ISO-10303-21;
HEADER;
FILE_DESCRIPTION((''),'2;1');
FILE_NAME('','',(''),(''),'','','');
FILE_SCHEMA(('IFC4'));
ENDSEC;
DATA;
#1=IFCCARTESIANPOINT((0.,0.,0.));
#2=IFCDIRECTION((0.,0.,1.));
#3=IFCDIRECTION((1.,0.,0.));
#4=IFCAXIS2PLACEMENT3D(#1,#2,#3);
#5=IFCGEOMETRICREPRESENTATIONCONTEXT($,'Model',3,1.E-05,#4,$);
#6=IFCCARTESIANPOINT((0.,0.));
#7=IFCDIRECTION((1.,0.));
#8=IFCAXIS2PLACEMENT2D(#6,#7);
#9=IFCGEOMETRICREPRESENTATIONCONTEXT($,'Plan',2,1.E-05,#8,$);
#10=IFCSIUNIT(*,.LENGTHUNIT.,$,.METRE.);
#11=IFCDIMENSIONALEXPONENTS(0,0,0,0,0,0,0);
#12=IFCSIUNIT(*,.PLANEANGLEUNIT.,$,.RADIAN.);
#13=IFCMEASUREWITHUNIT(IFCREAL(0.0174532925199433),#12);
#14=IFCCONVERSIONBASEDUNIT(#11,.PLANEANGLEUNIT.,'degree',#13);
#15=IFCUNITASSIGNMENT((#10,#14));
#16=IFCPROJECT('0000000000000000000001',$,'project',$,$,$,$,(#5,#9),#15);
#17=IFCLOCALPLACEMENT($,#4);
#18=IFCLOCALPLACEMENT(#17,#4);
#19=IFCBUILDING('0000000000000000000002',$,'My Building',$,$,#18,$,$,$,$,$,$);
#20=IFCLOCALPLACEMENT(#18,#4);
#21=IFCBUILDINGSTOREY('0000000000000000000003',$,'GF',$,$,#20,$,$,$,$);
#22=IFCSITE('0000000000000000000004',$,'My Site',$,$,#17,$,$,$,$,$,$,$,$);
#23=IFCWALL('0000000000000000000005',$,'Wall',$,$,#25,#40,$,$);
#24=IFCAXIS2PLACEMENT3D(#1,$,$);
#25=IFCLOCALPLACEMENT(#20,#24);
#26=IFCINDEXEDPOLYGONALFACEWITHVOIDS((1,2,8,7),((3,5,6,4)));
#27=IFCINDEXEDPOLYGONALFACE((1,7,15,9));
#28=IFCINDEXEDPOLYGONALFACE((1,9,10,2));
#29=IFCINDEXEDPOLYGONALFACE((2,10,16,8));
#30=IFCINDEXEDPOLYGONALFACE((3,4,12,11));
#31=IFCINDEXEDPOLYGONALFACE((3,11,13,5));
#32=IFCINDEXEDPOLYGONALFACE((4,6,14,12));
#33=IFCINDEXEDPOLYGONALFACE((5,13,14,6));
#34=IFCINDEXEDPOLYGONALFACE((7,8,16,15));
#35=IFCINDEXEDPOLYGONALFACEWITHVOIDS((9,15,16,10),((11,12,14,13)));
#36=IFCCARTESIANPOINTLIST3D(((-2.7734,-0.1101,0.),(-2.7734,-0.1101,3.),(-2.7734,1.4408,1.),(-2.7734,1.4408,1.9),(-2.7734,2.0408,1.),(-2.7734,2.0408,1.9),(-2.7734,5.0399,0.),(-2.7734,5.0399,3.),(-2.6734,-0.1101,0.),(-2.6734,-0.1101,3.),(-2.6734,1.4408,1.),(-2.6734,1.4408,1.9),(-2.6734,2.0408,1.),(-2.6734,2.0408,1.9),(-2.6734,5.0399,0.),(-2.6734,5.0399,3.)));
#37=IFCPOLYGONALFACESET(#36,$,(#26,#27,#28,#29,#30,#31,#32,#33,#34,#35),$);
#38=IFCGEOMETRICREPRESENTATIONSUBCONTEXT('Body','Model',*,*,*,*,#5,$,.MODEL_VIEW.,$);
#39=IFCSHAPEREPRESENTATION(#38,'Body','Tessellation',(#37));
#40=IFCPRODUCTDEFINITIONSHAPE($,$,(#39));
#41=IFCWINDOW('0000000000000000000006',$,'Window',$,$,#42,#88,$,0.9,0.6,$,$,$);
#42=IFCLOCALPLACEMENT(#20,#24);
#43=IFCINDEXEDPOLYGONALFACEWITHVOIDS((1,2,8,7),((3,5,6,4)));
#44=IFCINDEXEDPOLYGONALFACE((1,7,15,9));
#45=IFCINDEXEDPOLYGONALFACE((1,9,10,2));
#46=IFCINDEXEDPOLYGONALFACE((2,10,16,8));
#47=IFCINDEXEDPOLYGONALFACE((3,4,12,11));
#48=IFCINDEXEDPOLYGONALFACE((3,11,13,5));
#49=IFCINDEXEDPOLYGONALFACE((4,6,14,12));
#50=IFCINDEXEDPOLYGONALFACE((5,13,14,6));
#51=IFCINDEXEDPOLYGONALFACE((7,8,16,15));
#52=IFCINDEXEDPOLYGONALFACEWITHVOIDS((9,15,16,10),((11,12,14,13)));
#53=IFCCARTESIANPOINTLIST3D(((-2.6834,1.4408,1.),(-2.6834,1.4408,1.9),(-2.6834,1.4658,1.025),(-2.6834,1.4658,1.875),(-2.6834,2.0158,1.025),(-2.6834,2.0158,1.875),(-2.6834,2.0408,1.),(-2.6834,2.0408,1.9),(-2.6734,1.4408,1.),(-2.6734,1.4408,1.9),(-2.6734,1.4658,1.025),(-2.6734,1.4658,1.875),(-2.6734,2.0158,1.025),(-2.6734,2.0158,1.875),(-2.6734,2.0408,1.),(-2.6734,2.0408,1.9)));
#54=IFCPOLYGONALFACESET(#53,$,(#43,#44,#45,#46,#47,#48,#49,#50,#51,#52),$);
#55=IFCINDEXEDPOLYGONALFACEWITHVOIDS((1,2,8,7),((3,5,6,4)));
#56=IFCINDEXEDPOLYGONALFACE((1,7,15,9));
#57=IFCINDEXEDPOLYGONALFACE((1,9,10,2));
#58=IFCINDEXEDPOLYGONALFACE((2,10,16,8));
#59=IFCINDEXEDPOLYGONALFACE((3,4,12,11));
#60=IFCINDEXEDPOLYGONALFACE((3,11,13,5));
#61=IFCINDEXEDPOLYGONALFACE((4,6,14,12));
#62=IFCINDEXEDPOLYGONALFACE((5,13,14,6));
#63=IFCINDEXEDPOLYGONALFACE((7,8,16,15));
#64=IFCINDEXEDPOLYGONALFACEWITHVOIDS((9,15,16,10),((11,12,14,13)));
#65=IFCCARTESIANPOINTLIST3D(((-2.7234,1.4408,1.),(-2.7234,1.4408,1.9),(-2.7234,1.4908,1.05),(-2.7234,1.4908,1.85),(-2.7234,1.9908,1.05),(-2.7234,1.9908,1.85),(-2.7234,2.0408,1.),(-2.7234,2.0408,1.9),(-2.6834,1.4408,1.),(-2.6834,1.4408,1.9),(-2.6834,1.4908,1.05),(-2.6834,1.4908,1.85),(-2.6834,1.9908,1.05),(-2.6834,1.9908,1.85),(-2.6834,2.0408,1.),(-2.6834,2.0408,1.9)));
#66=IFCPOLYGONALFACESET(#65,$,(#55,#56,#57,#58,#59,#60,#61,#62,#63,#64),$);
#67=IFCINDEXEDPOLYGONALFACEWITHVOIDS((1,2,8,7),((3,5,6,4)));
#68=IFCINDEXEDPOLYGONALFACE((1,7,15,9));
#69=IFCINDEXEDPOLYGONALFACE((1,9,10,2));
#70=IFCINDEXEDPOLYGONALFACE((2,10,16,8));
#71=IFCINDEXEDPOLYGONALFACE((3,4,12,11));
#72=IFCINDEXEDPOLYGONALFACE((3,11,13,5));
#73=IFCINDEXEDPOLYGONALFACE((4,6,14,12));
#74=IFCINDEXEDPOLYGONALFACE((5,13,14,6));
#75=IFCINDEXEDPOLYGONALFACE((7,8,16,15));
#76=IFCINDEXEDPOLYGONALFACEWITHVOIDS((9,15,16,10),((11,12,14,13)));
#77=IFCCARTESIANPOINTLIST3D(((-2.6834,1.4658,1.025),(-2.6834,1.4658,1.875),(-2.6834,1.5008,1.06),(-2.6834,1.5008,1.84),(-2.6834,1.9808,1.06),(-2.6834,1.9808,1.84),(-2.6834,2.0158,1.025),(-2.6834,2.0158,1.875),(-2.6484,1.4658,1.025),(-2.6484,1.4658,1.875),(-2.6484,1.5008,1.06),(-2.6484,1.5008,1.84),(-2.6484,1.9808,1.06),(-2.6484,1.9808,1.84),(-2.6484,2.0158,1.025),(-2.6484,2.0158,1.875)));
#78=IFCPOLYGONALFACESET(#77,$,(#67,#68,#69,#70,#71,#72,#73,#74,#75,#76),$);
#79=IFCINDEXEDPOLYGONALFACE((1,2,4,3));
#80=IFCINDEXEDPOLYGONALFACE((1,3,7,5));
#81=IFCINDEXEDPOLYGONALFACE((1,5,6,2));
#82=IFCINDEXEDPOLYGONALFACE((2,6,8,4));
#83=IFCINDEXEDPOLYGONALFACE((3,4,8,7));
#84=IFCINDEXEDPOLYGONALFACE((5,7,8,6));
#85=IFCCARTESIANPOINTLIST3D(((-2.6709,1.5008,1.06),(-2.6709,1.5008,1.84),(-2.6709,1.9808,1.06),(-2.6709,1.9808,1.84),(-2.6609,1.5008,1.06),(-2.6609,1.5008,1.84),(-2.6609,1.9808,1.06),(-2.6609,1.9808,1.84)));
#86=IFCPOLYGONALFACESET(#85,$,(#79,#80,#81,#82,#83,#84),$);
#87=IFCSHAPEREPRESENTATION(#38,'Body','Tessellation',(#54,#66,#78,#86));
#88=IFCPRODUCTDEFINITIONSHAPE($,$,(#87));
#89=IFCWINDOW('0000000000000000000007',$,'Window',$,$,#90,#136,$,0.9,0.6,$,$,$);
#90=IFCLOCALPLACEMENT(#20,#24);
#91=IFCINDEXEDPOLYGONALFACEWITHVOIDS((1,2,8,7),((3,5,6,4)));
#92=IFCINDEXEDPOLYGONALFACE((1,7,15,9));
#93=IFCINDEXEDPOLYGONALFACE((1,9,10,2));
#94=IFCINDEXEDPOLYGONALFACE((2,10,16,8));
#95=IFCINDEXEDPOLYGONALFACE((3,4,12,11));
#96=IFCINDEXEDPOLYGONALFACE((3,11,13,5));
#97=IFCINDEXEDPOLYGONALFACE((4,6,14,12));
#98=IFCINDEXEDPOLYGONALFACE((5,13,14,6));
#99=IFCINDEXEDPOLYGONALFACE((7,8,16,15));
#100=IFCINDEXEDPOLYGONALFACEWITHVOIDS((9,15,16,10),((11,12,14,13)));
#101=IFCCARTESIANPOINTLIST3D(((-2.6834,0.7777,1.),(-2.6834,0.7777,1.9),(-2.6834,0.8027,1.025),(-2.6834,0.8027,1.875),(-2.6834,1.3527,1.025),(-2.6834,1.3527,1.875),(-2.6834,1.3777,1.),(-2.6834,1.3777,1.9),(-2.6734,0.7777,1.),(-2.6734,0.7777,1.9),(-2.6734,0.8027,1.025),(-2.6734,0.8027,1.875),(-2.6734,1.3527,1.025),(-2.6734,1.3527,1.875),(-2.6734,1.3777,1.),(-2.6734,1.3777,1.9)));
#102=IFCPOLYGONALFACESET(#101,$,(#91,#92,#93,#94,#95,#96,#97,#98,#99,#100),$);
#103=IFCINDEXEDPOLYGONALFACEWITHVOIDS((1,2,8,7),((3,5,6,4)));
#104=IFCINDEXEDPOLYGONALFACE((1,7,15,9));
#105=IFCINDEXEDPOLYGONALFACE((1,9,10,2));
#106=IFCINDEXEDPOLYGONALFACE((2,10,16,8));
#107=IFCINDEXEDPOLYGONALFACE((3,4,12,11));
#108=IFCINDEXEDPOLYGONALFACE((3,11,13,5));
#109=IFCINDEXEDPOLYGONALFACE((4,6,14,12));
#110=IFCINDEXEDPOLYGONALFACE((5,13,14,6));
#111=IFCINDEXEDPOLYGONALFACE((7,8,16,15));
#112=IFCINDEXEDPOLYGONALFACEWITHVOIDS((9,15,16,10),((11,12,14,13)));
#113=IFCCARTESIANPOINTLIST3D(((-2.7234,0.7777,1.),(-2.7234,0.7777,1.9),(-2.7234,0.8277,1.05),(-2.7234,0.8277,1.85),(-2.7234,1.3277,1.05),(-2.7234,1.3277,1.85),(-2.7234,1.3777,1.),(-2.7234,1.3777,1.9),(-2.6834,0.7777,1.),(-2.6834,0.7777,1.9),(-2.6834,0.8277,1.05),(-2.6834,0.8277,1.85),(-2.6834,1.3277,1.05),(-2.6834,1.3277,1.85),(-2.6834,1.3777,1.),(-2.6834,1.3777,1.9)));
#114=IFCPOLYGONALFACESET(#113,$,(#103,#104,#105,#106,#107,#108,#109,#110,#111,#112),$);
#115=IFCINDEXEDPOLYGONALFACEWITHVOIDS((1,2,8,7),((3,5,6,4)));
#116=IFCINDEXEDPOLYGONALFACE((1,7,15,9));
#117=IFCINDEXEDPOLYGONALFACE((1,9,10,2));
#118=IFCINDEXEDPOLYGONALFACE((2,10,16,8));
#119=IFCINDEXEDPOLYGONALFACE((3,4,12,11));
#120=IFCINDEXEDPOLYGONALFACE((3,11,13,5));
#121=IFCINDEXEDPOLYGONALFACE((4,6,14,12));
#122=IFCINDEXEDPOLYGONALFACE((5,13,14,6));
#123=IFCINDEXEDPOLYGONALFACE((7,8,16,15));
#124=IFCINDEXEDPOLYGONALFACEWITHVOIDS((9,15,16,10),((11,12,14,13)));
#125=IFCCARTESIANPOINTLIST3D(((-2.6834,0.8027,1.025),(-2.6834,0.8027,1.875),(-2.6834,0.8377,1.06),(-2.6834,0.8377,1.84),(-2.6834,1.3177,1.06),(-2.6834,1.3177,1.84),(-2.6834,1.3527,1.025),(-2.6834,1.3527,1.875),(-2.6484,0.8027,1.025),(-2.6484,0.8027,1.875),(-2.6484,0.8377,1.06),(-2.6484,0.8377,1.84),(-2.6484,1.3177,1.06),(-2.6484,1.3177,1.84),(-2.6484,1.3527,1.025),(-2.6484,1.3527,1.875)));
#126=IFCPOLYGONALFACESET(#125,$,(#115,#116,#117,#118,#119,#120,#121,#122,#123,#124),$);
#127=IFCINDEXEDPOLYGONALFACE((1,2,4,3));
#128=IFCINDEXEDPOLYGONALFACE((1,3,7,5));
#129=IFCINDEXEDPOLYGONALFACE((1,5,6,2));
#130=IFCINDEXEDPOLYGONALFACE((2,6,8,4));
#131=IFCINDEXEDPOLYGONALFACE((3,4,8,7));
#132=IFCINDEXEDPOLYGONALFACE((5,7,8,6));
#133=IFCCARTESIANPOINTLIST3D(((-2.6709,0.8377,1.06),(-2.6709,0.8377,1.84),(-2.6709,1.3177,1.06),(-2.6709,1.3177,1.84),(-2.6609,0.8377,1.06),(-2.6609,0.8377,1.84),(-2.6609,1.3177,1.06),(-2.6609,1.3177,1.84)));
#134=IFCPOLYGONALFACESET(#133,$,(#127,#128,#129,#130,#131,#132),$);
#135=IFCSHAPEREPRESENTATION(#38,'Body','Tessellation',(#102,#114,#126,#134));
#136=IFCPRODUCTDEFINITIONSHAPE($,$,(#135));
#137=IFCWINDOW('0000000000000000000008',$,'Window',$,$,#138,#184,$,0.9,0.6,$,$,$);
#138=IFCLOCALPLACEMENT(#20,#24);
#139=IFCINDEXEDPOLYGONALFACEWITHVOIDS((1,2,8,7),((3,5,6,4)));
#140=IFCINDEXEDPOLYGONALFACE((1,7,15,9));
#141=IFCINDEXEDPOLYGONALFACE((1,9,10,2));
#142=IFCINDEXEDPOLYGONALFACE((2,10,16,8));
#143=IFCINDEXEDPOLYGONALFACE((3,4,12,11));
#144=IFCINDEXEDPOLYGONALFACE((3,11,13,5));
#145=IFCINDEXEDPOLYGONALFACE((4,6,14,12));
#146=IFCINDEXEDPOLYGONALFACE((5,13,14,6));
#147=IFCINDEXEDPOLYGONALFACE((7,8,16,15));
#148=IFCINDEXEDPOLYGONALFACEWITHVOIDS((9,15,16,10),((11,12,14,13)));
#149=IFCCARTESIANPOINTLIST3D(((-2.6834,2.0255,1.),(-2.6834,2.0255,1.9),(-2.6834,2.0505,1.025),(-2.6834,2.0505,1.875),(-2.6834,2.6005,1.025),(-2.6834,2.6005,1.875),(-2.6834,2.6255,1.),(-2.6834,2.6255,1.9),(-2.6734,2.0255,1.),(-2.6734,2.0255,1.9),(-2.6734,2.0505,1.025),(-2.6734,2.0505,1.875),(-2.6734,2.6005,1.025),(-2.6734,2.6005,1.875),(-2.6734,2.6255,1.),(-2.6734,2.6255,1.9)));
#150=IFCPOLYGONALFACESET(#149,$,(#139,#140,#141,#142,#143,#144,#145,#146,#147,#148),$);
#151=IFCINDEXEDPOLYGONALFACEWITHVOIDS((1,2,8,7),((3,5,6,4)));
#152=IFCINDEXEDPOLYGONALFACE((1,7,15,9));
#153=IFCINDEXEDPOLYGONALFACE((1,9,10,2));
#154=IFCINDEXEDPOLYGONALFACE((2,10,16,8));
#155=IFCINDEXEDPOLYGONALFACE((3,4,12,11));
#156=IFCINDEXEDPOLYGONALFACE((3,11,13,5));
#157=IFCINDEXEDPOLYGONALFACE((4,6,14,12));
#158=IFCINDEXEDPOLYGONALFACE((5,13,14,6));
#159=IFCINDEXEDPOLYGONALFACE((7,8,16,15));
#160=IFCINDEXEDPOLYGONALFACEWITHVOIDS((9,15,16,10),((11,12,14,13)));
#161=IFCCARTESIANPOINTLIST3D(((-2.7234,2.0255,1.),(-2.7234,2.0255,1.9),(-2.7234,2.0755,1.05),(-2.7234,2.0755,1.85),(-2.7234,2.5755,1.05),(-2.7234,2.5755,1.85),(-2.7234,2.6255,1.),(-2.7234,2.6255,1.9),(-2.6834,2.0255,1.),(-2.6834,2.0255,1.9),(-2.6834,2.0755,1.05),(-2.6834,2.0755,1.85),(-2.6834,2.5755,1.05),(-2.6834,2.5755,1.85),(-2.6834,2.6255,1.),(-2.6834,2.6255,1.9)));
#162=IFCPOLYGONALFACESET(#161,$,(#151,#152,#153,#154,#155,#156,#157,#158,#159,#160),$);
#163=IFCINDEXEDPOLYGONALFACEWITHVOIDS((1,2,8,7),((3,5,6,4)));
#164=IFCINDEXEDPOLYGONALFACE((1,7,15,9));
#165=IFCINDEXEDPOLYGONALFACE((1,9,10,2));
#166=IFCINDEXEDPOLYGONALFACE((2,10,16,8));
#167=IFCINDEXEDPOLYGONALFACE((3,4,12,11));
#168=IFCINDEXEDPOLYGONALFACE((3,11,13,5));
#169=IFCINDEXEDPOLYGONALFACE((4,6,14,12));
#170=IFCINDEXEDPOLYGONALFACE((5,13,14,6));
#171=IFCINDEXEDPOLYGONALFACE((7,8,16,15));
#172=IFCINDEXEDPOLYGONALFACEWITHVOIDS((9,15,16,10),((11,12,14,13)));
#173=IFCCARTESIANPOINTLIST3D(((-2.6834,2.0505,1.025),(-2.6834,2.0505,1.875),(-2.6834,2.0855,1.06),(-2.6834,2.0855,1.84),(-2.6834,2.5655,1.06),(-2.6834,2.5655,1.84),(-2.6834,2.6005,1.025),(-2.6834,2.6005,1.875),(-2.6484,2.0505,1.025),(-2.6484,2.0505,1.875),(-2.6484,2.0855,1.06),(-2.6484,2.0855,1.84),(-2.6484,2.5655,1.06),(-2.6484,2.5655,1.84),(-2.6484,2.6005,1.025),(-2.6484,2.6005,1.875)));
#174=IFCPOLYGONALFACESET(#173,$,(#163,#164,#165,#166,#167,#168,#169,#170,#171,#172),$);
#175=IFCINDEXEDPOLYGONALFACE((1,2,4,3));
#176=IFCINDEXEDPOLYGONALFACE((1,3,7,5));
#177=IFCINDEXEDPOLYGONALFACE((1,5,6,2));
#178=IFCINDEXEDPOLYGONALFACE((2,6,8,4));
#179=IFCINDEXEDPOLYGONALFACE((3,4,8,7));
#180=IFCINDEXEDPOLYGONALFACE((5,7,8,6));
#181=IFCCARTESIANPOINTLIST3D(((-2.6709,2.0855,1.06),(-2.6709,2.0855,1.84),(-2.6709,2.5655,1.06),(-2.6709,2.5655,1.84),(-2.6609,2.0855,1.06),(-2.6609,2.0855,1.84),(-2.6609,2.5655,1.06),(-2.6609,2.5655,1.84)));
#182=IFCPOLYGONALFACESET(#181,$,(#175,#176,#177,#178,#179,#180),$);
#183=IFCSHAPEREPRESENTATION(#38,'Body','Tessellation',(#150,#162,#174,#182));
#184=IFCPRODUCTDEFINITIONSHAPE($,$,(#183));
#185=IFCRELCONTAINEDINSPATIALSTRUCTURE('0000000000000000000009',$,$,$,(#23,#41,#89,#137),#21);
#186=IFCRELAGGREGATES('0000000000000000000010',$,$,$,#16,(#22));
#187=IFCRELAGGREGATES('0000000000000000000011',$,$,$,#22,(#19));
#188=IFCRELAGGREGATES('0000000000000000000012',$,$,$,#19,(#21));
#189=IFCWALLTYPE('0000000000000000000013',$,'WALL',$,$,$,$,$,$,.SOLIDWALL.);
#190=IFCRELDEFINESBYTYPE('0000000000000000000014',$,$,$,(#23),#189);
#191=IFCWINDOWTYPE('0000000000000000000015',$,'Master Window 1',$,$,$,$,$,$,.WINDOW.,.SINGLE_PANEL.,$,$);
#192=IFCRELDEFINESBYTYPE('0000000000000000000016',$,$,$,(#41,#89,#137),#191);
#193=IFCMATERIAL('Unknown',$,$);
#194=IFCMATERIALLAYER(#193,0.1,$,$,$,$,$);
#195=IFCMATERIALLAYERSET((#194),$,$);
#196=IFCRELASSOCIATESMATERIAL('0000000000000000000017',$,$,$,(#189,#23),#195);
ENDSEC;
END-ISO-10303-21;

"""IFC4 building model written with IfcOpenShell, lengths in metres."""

from ifc_helpers import new_model, entity, si_unit, converted_unit, frame, origin_with_axes, origin_2d_with_axis, place, context, subcontext, project, spatial, line, indexed_curve, outline, extrude, shape, source, transform, mapped, material, layer, layer_set, layer_usage, type_object, type_shapes, element, fill, save


model = new_model("IFC4")

# Units and contexts
model_context = context("Model", 3, precision=1e-05, world=origin_with_axes())
plan_context = context("Plan", 2, precision=1e-05, world=origin_2d_with_axis())
body_context_1 = subcontext(model_context, "Body", "Model", "MODEL_VIEW")
body_context_2 = subcontext(plan_context, "Body", "Plan", "PLAN_VIEW")
ifc_project = project(units=[si_unit("LENGTHUNIT", "METRE"), converted_unit("PLANEANGLEUNIT", "degree", entity("IfcReal", 0.0174532925199433), si_unit("PLANEANGLEUNIT", "RADIAN"), dimensions=[0, 0, 0, 0, 0, 0, 0])], contexts=[model_context, plan_context])

# Site, building, storey
site_placement = place(None, origin_with_axes())
site = spatial("IfcSite", under=ifc_project, at=site_placement, Name="My Site")
building_placement = place(site_placement, origin_with_axes())
building = spatial("IfcBuilding", under=site, at=building_placement, Name="My Building")
storey_placement = place(building_placement, origin_with_axes())
storey = spatial("IfcBuildingStorey", under=building, at=storey_placement, Name="GF")

# Shared definitions
ifc_material = material(Name="Unknown")

# Shared definitions
ifc_layer_1 = layer(ifc_material, 0.1)
ifc_layer_set_1 = layer_set([ifc_layer_1])
wall_type_1 = type_object("IfcWallType", Name="WALL", PredefinedType="SOLIDWALL", material=ifc_layer_set_1)

# Shared definitions
shared_shape_1 = source(origin_with_axes(), body_context_1, "Body", "SweptSolid", [
    extrude(outline(indexed_curve([(0.0, 0.0), (0.6, 0.0), (0.6, 0.9), (0.0, 0.9)], segments=[line(1, 2, 3, 4, 1)])), frame((0.0, -0.6, 0.0), z_axis=(0.0, -1.0, 0.0), x_axis=(1.0, 0.0, 0.0)), (0.0, 0.0, -1.0), 1.2),
])
window_type_1 = type_object("IfcWindowType", Name="Master Window 1", PartitioningType="SINGLE_PANEL", PredefinedType="WINDOW")
shared_shape_2 = source(origin_with_axes(), body_context_1, "Body", "SweptSolid", [
    extrude(outline(indexed_curve([(0.0, 0.0), (0.6, 0.0), (0.6, 0.9), (0.0, 0.9)], segments=[line(1, 2, 3, 4, 1)]), holes=[indexed_curve([(0.025, 0.025), (0.575, 0.025), (0.575, 0.875), (0.025, 0.875)], segments=[line(1, 2, 3, 4, 1)])]), frame((0.0, 0.09, 0.0), z_axis=(0.0, -1.0, 0.0), x_axis=(1.0, 0.0, 0.0)), (0.0, 0.0, -1.0), 0.01),
    extrude(outline(indexed_curve([(0.0, 0.0), (0.6, 0.0), (0.6, 0.9), (0.0, 0.9)], segments=[line(1, 2, 3, 4, 1)]), holes=[indexed_curve([(0.05, 0.05), (0.55, 0.05), (0.55, 0.85), (0.05, 0.85)], segments=[line(1, 2, 3, 4, 1)])]), frame((0.0, 0.05, 0.0), z_axis=(0.0, -1.0, 0.0), x_axis=(1.0, 0.0, 0.0)), (0.0, 0.0, -1.0), 0.04),
    extrude(outline(indexed_curve([(0.0, 0.0), (0.55, 0.0), (0.55, 0.85), (0.0, 0.85)], segments=[line(1, 2, 3, 4, 1)]), holes=[indexed_curve([(0.035, 0.035), (0.515, 0.035), (0.515, 0.815), (0.035, 0.815)], segments=[line(1, 2, 3, 4, 1)])]), frame((0.025, 0.09, 0.025), z_axis=(0.0, -1.0, 0.0), x_axis=(1.0, 0.0, 0.0)), (0.0, 0.0, -1.0), 0.035),
    extrude(outline(indexed_curve([(0.035, 0.035), (0.515, 0.035), (0.515, 0.815), (0.035, 0.815)], segments=[line(1, 2, 3, 4, 1)])), frame((0.025, 0.1025, 0.025), z_axis=(0.0, -1.0, 0.0), x_axis=(1.0, 0.0, 0.0)), (0.0, 0.0, -1.0), 0.01),
])
shared_shape_3 = source(origin_with_axes(), body_context_2, "Body", "Curve2D", [
    entity("IfcIndexedPolyCurve", entity("IfcCartesianPointList2D", [[0.05, 0.05], [0.55, 0.05]])),
    entity("IfcIndexedPolyCurve", entity("IfcCartesianPointList2D", [[0.0, 0.1], [0.025, 0.1], [0.025, 0.09], [0.05, 0.09], [0.05, 0.05], [0.0, 0.05]]), [entity("IfcLineIndex", [1, 2, 3, 4, 5, 6, 1])]),
    entity("IfcIndexedPolyCurve", entity("IfcCartesianPointList2D", [[0.6, 0.1], [0.575, 0.1], [0.575, 0.09], [0.55, 0.09], [0.55, 0.05], [0.6, 0.05]]), [entity("IfcLineIndex", [1, 2, 3, 4, 5, 6, 1])]),
    entity("IfcIndexedPolyCurve", entity("IfcCartesianPointList2D", [[0.025, 0.09], [0.06, 0.09], [0.06, 0.125], [0.025, 0.125]]), [entity("IfcLineIndex", [1, 2, 3, 4, 1])]),
    entity("IfcIndexedPolyCurve", entity("IfcCartesianPointList2D", [[0.575, 0.09], [0.54, 0.09], [0.54, 0.125], [0.575, 0.125]]), [entity("IfcLineIndex", [1, 2, 3, 4, 1])]),
    entity("IfcIndexedPolyCurve", entity("IfcCartesianPointList2D", [[0.06, 0.09], [0.54, 0.09]])),
    entity("IfcIndexedPolyCurve", entity("IfcCartesianPointList2D", [[0.06, 0.125], [0.54, 0.125]])),
    entity("IfcIndexedPolyCurve", entity("IfcCartesianPointList2D", [[0.06, 0.1075], [0.54, 0.1075]])),
])
type_shapes(window_type_1, [shared_shape_2, shared_shape_3])

# Wall, opening, window
ifc_layer_usage_1 = layer_usage(ifc_layer_set_1, "AXIS2", "POSITIVE", 0.0)
wall_1_placement = place(storey_placement, frame((-2.7734, 5.0399, 0.0), z_axis=(0.0, 0.0, 1.0), x_axis=(0.0, -1.0, 0.0)))
wall_1 = element("IfcWall", 1, at=wall_1_placement, inside=storey, type_object=wall_type_1, material=ifc_layer_usage_1, Name="Wall", context=body_context_1, shape_type="SweptSolid", body=[
    extrude(outline(indexed_curve([(0.0, 0.0), (0.0, 0.1), (5.15, 0.1), (5.15, 0.0)], segments=[line(1, 2, 3, 4, 1)])), origin_with_axes(), (0.0, 0.0, 1.0), 3.0),
])
opening_1_placement = place(wall_1_placement, frame((2.9991, 0.0, 1.0), z_axis=(0.0, 0.0, 1.0), x_axis=(1.0, 0.0, 0.0)))
opening_1 = element("IfcOpeningElement", 2, at=opening_1_placement, cuts=wall_1, PredefinedType="OPENING", context=body_context_1, shape_type="MappedRepresentation", body=[
    mapped(shared_shape_1, transform((0.0, 0.0, 0.0), x_axis=(1.0, 0.0, 0.0), y_axis=(0.0, 1.0, 0.0), z_axis=(0.0, 0.0, 1.0), scale=1.0)),
])
window_1_placement = place(opening_1_placement, frame((0.0, 0.0, 0.0), z_axis=(0.0, 0.0, 1.0), x_axis=(1.0, 0.0, 0.0)))
window_1 = element("IfcWindow", 3, at=window_1_placement, inside=storey, type_object=window_type_1, Name="Window", OverallHeight=0.9, OverallWidth=0.6, shapes=[
    shape(body_context_1, "Body", "MappedRepresentation", [mapped(shared_shape_2, transform((0.0, 0.0, 0.0), x_axis=(1.0, 0.0, 0.0), y_axis=(0.0, 1.0, 0.0), z_axis=(0.0, 0.0, 1.0), scale=1.0))]),
    shape(body_context_2, "Body", "MappedRepresentation", [mapped(shared_shape_3, transform((0.0, 0.0, 0.0), x_axis=(1.0, 0.0, 0.0), y_axis=(0.0, 1.0, 0.0), z_axis=(0.0, 0.0, 1.0), scale=1.0))]),
])
fill(opening_1, window_1)

# Windows
placement_1 = place(storey_placement, frame((-2.7734, 5.0399, 0.0), z_axis=(0.0, 0.0, 1.0), x_axis=(0.0, -1.0, 0.0)))
placement_2 = place(placement_1, frame((3.6622, 0.0, 1.0), z_axis=(0.0, 0.0, 1.0), x_axis=(1.0, 0.0, 0.0)))
window_2_placement = place(placement_2, frame((0.0, 0.0, 0.0), z_axis=(0.0, 0.0, 1.0), x_axis=(1.0, 0.0, 0.0)))
element("IfcWindow", 4, at=window_2_placement, inside=storey, type_object=window_type_1, Name="Window", OverallHeight=0.9, OverallWidth=0.6, shapes=[
    shape(body_context_1, "Body", "MappedRepresentation", [mapped(shared_shape_2, transform((0.0, 0.0, 0.0), x_axis=(1.0, 0.0, 0.0), y_axis=(0.0, 1.0, 0.0), z_axis=(0.0, 0.0, 1.0), scale=1.0))]),
    shape(body_context_2, "Body", "MappedRepresentation", [mapped(shared_shape_3, transform((0.0, 0.0, 0.0), x_axis=(1.0, 0.0, 0.0), y_axis=(0.0, 1.0, 0.0), z_axis=(0.0, 0.0, 1.0), scale=1.0))]),
])
placement_3 = place(placement_1, frame((2.4144, 0.0, 1.0), z_axis=(0.0, 0.0, 1.0), x_axis=(1.0, 0.0, 0.0)))
window_3_placement = place(placement_3, frame((0.0, 0.0, 0.0), z_axis=(0.0, 0.0, 1.0), x_axis=(1.0, 0.0, 0.0)))
element("IfcWindow", 5, at=window_3_placement, inside=storey, type_object=window_type_1, Name="Window", OverallHeight=0.9, OverallWidth=0.6, shapes=[
    shape(body_context_1, "Body", "MappedRepresentation", [mapped(shared_shape_2, transform((0.0, 0.0, 0.0), x_axis=(1.0, 0.0, 0.0), y_axis=(0.0, 1.0, 0.0), z_axis=(0.0, 0.0, 1.0), scale=1.0))]),
    shape(body_context_2, "Body", "MappedRepresentation", [mapped(shared_shape_3, transform((0.0, 0.0, 0.0), x_axis=(1.0, 0.0, 0.0), y_axis=(0.0, 1.0, 0.0), z_axis=(0.0, 0.0, 1.0), scale=1.0))]),
])

save(model, "model.ifc")
